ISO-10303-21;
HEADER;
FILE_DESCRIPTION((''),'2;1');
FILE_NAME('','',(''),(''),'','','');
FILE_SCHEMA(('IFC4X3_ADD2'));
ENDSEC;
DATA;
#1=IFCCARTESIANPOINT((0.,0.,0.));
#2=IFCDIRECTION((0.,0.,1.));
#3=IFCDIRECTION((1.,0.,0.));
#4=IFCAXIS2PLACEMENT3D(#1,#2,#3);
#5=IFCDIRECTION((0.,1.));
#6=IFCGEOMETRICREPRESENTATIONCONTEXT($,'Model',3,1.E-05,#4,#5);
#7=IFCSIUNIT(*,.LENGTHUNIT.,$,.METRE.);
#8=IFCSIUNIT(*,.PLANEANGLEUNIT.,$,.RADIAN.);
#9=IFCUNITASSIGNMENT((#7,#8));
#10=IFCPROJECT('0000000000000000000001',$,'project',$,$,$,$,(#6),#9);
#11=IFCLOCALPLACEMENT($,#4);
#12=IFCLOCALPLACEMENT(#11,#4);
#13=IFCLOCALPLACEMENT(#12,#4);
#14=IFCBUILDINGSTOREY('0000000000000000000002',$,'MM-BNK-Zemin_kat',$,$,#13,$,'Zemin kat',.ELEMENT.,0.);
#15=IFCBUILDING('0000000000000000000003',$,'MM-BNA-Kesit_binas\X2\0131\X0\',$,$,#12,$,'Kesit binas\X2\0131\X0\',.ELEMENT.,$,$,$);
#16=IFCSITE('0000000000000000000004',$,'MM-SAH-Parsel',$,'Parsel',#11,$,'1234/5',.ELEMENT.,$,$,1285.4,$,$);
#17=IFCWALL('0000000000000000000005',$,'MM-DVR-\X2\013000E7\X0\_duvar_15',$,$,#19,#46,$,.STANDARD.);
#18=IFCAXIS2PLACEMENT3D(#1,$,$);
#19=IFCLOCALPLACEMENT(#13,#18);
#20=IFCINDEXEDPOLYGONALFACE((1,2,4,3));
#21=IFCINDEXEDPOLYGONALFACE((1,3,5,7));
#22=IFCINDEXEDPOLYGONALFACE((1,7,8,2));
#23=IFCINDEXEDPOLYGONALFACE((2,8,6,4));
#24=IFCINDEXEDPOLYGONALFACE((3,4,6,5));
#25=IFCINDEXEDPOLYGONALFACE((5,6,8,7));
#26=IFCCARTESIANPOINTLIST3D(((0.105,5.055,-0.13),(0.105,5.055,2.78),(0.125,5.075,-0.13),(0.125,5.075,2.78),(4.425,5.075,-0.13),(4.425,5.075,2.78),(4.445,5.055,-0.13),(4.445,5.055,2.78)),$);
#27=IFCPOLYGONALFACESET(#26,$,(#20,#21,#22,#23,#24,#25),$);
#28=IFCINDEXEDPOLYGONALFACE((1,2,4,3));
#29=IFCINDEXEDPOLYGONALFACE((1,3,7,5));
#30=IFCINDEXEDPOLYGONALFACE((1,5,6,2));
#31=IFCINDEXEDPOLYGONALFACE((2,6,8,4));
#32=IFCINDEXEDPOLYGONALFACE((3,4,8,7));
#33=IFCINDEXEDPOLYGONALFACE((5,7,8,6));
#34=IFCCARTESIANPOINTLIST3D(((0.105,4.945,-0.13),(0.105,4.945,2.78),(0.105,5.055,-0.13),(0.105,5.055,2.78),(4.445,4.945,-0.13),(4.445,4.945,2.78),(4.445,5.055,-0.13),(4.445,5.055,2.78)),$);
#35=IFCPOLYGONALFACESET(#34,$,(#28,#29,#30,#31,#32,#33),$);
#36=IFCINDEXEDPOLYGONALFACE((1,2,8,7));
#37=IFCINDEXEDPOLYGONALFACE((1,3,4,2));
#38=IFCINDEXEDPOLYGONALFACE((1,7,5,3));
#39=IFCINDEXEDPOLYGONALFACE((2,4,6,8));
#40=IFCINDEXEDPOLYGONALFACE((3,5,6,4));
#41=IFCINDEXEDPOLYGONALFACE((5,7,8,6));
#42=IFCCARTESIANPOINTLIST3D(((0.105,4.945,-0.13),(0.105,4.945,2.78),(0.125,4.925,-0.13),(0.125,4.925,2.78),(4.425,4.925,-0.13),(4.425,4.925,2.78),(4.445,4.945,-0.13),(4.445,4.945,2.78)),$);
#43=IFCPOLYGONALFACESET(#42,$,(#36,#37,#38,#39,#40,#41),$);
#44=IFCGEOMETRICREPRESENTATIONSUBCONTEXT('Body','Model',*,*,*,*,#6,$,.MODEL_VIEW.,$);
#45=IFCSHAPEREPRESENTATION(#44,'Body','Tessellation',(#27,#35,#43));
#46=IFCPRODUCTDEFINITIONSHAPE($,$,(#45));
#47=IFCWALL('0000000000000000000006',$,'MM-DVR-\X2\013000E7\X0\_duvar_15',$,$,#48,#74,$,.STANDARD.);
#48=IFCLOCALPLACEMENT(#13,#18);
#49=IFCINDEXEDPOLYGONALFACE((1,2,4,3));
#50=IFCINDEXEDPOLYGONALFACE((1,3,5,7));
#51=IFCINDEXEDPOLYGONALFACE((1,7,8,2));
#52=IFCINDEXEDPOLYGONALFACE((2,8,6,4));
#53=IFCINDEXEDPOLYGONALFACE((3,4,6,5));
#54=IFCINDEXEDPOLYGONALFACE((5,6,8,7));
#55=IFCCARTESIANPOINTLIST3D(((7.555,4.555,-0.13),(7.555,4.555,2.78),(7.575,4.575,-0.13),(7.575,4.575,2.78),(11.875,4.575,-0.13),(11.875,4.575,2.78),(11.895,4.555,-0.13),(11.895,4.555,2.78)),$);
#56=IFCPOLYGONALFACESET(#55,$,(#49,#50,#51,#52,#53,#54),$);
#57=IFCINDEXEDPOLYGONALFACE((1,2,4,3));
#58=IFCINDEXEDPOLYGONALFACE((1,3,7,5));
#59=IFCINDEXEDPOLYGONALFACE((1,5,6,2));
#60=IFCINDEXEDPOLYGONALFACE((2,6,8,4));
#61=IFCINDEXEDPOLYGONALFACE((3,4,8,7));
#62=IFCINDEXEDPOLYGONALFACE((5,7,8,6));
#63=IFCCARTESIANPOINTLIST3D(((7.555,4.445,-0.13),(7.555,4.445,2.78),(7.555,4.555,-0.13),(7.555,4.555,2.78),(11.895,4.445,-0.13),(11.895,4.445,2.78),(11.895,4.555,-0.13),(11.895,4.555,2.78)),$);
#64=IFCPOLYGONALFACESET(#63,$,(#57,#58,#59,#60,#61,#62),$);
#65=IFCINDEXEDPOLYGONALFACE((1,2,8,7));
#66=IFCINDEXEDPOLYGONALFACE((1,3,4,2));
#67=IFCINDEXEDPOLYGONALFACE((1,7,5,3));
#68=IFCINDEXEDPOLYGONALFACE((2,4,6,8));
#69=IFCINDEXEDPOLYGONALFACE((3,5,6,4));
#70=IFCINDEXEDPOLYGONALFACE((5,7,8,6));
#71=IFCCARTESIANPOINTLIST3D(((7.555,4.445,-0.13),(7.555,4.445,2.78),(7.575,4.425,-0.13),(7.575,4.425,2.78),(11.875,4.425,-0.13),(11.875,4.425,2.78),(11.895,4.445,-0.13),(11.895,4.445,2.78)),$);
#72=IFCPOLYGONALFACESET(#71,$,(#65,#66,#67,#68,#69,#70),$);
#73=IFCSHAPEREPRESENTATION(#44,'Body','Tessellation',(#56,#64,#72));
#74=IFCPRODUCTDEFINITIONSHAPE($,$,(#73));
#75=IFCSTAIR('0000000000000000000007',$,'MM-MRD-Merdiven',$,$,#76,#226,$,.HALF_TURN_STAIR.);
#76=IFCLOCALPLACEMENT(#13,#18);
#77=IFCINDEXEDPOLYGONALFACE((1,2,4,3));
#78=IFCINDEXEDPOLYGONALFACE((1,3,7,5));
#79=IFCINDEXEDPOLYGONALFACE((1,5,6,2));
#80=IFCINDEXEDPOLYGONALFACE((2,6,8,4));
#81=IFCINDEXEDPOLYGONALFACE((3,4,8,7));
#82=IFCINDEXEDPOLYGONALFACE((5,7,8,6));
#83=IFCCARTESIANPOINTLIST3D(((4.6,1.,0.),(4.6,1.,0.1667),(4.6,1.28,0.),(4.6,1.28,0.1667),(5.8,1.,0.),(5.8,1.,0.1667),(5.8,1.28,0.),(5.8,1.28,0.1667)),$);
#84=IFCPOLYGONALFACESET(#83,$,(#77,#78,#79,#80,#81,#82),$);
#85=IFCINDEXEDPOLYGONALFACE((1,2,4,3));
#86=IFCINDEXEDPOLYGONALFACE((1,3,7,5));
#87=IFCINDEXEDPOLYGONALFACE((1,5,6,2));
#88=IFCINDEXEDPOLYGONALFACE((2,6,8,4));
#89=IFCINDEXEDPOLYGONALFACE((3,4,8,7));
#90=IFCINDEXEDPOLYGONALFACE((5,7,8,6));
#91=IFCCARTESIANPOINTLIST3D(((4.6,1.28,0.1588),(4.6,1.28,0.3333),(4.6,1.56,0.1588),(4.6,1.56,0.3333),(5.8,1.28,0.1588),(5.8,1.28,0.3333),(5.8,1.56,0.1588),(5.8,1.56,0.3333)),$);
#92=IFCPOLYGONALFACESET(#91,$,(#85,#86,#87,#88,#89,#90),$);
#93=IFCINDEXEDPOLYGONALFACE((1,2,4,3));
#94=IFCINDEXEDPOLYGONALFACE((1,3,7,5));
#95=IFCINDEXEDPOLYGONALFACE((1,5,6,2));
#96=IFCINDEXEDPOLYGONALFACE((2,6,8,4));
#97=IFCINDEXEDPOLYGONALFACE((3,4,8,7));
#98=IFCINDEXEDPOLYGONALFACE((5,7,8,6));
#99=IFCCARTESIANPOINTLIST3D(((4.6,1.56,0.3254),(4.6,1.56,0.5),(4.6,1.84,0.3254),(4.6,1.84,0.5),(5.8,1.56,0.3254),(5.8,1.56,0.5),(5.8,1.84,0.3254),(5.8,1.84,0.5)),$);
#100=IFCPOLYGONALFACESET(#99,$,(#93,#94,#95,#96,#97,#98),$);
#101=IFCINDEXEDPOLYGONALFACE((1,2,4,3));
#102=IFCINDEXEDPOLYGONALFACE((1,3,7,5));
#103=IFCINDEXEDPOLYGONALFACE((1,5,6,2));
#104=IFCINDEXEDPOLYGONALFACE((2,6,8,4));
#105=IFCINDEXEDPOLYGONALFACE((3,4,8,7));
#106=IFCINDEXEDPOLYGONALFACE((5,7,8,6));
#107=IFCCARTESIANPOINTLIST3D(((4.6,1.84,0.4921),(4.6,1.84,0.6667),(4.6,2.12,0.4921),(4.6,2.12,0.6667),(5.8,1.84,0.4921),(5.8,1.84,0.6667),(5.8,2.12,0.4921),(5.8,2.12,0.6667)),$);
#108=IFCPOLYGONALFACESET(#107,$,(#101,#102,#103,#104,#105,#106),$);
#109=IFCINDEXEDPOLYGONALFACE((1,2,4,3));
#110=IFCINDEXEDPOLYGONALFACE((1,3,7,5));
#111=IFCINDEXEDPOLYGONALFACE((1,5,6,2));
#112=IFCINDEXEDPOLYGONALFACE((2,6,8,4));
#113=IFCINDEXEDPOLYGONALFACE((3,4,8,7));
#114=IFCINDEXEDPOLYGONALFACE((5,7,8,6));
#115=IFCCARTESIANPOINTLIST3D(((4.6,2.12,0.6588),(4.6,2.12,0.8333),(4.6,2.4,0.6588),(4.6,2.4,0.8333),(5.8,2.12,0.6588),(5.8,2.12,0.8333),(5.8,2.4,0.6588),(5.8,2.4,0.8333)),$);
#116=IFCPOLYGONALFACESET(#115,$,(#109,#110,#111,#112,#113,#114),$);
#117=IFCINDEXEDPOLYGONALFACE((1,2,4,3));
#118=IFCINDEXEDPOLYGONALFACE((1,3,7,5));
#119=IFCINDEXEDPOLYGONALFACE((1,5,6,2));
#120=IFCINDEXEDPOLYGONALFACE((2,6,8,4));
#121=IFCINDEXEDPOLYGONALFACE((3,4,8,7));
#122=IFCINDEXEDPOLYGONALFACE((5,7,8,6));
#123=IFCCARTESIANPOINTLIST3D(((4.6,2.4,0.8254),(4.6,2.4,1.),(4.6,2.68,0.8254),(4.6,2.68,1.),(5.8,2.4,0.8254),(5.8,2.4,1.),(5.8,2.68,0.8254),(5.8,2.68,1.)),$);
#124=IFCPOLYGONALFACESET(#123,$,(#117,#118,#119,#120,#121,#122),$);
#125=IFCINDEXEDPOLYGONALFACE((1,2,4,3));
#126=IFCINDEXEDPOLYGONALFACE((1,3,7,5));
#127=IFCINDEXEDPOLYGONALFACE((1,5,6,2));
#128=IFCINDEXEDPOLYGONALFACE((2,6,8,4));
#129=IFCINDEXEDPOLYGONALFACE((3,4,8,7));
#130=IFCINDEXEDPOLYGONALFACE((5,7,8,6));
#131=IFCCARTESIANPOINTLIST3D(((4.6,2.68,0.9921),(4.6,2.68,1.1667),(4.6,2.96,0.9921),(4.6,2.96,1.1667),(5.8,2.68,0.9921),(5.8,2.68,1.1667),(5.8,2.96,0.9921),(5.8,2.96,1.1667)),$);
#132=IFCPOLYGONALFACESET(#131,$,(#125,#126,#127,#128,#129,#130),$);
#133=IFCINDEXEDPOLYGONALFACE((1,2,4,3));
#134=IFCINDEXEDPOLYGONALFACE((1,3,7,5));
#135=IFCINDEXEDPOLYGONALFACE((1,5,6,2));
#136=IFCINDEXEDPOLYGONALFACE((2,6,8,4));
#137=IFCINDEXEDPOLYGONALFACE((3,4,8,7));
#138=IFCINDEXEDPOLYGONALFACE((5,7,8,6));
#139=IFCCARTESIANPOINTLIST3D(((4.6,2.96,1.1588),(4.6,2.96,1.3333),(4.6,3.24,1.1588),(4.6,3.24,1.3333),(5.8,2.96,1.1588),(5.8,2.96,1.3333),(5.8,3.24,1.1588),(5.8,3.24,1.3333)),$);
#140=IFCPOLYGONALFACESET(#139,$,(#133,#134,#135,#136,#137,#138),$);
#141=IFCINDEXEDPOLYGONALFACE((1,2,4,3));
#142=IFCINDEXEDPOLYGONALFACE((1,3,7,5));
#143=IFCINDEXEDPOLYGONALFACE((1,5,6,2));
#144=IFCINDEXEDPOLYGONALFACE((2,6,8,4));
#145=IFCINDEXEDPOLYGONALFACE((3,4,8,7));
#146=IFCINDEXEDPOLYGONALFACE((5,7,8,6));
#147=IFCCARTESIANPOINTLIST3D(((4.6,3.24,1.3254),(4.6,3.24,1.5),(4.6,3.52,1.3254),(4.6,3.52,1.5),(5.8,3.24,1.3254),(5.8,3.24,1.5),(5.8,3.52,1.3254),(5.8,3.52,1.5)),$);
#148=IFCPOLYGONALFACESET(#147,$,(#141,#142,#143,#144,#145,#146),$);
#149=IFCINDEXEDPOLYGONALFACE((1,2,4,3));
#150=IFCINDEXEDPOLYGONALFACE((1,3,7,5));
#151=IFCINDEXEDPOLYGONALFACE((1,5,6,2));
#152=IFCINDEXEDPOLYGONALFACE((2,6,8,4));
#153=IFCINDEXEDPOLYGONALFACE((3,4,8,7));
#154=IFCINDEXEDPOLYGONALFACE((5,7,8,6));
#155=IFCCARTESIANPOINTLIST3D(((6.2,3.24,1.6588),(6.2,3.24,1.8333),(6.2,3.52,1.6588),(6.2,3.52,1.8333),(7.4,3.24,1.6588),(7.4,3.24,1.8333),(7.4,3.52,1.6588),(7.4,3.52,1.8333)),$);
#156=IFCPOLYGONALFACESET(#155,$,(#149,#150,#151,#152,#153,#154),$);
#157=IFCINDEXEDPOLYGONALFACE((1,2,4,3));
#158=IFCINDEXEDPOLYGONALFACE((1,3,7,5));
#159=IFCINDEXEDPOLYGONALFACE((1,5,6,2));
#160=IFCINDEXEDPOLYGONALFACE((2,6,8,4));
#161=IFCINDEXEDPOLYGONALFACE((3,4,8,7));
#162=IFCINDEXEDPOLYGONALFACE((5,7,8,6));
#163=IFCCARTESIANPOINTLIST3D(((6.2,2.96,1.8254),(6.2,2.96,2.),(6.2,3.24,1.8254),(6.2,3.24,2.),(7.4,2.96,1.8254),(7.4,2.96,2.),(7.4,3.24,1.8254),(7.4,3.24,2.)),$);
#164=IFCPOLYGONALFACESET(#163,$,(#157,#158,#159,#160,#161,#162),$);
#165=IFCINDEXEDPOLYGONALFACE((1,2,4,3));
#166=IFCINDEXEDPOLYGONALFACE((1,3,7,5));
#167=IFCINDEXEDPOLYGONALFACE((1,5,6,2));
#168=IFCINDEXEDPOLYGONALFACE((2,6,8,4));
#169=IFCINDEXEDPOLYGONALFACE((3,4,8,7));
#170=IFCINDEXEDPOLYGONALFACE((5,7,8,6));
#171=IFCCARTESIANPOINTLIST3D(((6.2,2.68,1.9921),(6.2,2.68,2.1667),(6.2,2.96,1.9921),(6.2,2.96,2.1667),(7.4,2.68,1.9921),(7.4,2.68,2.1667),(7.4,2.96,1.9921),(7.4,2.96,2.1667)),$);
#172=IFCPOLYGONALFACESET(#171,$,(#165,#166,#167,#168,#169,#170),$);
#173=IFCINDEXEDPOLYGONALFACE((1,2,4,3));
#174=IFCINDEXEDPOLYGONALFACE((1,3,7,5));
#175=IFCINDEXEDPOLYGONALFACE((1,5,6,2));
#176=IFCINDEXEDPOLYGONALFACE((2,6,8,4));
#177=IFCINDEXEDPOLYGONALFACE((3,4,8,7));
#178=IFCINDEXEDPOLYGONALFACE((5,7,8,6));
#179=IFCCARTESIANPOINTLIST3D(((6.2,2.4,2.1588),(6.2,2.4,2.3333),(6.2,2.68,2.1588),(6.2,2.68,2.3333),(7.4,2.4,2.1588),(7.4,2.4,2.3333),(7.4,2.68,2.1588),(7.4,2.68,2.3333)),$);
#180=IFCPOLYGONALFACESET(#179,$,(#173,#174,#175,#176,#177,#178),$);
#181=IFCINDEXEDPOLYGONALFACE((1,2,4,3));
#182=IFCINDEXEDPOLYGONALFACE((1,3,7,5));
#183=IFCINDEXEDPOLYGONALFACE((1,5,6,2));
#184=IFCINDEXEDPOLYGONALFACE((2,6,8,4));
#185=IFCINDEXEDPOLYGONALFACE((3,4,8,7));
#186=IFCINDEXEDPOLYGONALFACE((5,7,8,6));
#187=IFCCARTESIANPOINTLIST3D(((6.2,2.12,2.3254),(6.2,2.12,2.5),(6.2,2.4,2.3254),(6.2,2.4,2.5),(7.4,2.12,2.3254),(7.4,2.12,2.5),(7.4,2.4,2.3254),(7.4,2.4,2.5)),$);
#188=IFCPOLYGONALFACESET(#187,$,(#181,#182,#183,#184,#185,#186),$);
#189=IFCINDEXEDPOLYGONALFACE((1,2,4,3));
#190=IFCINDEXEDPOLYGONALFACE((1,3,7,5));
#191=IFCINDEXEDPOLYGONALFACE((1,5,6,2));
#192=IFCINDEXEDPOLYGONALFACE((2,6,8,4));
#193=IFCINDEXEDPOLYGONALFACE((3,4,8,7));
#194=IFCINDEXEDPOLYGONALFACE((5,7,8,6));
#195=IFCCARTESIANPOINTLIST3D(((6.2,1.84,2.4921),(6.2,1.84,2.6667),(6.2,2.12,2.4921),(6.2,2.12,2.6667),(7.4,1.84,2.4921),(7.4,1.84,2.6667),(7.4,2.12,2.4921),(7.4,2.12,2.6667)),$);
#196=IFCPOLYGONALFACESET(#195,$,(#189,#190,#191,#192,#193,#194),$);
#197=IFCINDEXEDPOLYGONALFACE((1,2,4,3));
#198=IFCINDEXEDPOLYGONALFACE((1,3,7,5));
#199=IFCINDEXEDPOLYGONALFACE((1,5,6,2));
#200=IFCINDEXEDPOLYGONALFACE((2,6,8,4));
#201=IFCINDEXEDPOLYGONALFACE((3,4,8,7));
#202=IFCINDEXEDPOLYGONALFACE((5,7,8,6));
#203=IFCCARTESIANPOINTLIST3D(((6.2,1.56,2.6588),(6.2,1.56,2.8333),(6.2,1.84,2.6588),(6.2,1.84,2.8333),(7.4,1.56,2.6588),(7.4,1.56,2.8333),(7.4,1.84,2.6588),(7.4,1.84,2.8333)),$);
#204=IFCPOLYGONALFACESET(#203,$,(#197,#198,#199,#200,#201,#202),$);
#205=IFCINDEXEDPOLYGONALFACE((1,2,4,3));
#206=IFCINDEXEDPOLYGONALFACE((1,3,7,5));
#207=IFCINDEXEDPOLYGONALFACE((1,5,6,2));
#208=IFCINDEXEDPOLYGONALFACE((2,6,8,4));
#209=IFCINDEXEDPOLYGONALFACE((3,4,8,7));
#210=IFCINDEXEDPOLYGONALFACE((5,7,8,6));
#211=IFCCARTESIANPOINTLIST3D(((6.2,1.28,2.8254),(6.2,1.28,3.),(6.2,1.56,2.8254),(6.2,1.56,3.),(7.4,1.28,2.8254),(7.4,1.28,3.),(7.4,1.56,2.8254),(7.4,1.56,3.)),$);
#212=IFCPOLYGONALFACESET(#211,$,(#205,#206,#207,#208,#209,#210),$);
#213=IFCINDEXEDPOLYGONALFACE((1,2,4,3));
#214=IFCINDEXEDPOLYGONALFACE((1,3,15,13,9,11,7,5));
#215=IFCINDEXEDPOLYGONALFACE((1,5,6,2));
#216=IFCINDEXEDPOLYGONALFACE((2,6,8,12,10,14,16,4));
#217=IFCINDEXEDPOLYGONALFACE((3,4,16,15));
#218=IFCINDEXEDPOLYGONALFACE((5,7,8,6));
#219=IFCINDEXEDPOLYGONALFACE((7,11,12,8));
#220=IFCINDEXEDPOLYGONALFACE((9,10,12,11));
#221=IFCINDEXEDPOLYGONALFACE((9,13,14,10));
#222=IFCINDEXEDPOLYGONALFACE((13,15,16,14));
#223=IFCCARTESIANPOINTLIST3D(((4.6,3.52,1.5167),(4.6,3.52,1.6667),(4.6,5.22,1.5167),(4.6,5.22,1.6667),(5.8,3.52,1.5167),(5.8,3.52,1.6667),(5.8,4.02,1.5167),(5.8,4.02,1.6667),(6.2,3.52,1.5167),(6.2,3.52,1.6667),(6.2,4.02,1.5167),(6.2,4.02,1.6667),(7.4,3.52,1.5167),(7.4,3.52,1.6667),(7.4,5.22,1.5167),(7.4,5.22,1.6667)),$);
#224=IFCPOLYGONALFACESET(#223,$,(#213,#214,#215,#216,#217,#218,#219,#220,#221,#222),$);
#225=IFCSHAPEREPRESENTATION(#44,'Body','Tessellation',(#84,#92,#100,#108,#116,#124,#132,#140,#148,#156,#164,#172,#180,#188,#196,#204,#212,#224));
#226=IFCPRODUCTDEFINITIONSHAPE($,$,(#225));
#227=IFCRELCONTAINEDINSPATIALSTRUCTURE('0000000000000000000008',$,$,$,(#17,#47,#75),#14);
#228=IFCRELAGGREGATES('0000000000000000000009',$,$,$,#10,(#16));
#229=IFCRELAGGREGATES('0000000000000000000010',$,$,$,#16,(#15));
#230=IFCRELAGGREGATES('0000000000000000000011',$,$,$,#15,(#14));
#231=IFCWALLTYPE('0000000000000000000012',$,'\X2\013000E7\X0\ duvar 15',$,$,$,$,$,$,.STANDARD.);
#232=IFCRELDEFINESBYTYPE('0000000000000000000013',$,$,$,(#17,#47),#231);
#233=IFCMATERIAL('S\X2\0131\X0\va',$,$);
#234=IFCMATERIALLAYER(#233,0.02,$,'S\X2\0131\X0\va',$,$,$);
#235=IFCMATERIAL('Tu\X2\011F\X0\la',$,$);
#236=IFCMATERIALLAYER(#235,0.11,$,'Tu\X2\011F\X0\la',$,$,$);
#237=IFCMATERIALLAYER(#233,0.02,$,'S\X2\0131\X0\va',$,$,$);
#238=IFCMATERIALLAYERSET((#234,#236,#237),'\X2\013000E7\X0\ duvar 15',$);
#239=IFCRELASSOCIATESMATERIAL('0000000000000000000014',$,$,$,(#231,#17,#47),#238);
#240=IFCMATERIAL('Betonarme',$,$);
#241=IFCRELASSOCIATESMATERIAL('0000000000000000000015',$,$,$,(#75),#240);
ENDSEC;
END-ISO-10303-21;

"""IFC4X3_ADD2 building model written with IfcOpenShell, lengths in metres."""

from ifc_helpers import new_model, si_unit, direction, frame, origin, origin_with_axes, place, context, subcontext, project, spatial, polyline, outline, extrude, material, layer, layer_set, type_object, element, save


model = new_model("IFC4X3_ADD2")

# Units and contexts
model_context = context("Model", 3, precision=1e-05, world=origin_with_axes(), true_north=direction((0.0, 1.0)))
body_context = subcontext(model_context, "Body", "Model", "MODEL_VIEW")
ifc_project = project(units=[si_unit("LENGTHUNIT", "METRE"), si_unit("PLANEANGLEUNIT", "RADIAN")], contexts=[model_context])

# Site, building, storey
site_placement = place(None, origin_with_axes())
site = spatial("IfcSite", under=ifc_project, at=site_placement, Name="MM-SAH-Parsel", ObjectType="Parsel", LongName="1234/5", CompositionType="ELEMENT", RefElevation=1285.4)
building_placement = place(site_placement, origin_with_axes())
building = spatial("IfcBuilding", under=site, at=building_placement, Name="MM-BNA-Kesit_binası", LongName="Kesit binası", CompositionType="ELEMENT")
storey_placement = place(building_placement, origin_with_axes())
storey = spatial("IfcBuildingStorey", under=building, at=storey_placement, Name="MM-BNK-Zemin_kat", LongName="Zemin kat", CompositionType="ELEMENT", Elevation=0.0)

# Shared definitions
ifc_material_1 = material(Name="Betonarme")

# Shared definitions
ifc_material_2 = material(Name="Tuğla")

# Shared definitions
ifc_material_3 = material(Name="Sıva")
ifc_layer_1 = layer(ifc_material_3, 0.02, Name="Sıva")
ifc_layer_2 = layer(ifc_material_2, 0.11, Name="Tuğla")
ifc_layer_3 = layer(ifc_material_3, 0.02, Name="Sıva")
ifc_layer_set_1 = layer_set([ifc_layer_1, ifc_layer_2, ifc_layer_3], Name="İç duvar 15")
wall_type_1 = type_object("IfcWallType", Name="İç duvar 15", PredefinedType="STANDARD", material=ifc_layer_set_1)

# Walls
wall_1_placement = place(storey_placement, frame((0.0, 0.5, 0.0), z_axis=(0.0, 0.0, 1.0), x_axis=(1.0, 0.0, 0.0)))
element("IfcWall", 1, at=wall_1_placement, inside=storey, type_object=wall_type_1, material=ifc_layer_set_1, Name="MM-DVR-İç_duvar_15", PredefinedType="STANDARD", context=body_context, shape_type="SweptSolid", body=[
    extrude(outline(polyline([(0.125, 4.575), (4.425, 4.575), (4.445, 4.555), (0.105, 4.555), (0.125, 4.575)])), frame((0.0, 0.0, -0.13)), (0.0, 0.0, 1.0), 2.91),
    extrude(outline(polyline([(0.105, 4.555), (4.445, 4.555), (4.445, 4.445), (0.105, 4.445), (0.105, 4.555)])), frame((0.0, 0.0, -0.13)), (0.0, 0.0, 1.0), 2.91),
    extrude(outline(polyline([(0.105, 4.445), (4.445, 4.445), (4.425, 4.425), (0.125, 4.425), (0.105, 4.445)])), frame((0.0, 0.0, -0.13)), (0.0, 0.0, 1.0), 2.91),
])
wall_2_placement = place(storey_placement, origin_with_axes())
element("IfcWall", 2, at=wall_2_placement, inside=storey, type_object=wall_type_1, material=ifc_layer_set_1, Name="MM-DVR-İç_duvar_15", PredefinedType="STANDARD", context=body_context, shape_type="SweptSolid", body=[
    extrude(outline(polyline([(7.575, 4.575), (11.875, 4.575), (11.895, 4.555), (7.555, 4.555), (7.575, 4.575)])), frame((0.0, 0.0, -0.13)), (0.0, 0.0, 1.0), 2.91),
    extrude(outline(polyline([(7.555, 4.555), (11.895, 4.555), (11.895, 4.445), (7.555, 4.445), (7.555, 4.555)])), frame((0.0, 0.0, -0.13)), (0.0, 0.0, 1.0), 2.91),
    extrude(outline(polyline([(7.555, 4.445), (11.895, 4.445), (11.875, 4.425), (7.575, 4.425), (7.555, 4.445)])), frame((0.0, 0.0, -0.13)), (0.0, 0.0, 1.0), 2.91),
])

# Stair
stair_placement = place(storey_placement, origin_with_axes())
element("IfcStair", 3, at=stair_placement, inside=storey, material=ifc_material_1, Name="MM-MRD-Merdiven", PredefinedType="HALF_TURN_STAIR", context=body_context, shape_type="SweptSolid", body=[
    extrude(outline(polyline([(5.8, 1.0), (5.8, 1.28), (4.6, 1.28), (4.6, 1.0), (5.8, 1.0)])), origin(), (0.0, 0.0, 1.0), 0.1667),
    extrude(outline(polyline([(5.8, 1.28), (5.8, 1.56), (4.6, 1.56), (4.6, 1.28), (5.8, 1.28)])), frame((0.0, 0.0, 0.1588)), (0.0, 0.0, 1.0), 0.1746),
    extrude(outline(polyline([(5.8, 1.56), (5.8, 1.84), (4.6, 1.84), (4.6, 1.56), (5.8, 1.56)])), frame((0.0, 0.0, 0.3254)), (0.0, 0.0, 1.0), 0.1746),
    extrude(outline(polyline([(5.8, 1.84), (5.8, 2.12), (4.6, 2.12), (4.6, 1.84), (5.8, 1.84)])), frame((0.0, 0.0, 0.4921)), (0.0, 0.0, 1.0), 0.1746),
    extrude(outline(polyline([(5.8, 2.12), (5.8, 2.4), (4.6, 2.4), (4.6, 2.12), (5.8, 2.12)])), frame((0.0, 0.0, 0.6588)), (0.0, 0.0, 1.0), 0.1746),
    extrude(outline(polyline([(5.8, 2.4), (5.8, 2.68), (4.6, 2.68), (4.6, 2.4), (5.8, 2.4)])), frame((0.0, 0.0, 0.8254)), (0.0, 0.0, 1.0), 0.1746),
    extrude(outline(polyline([(5.8, 2.68), (5.8, 2.96), (4.6, 2.96), (4.6, 2.68), (5.8, 2.68)])), frame((0.0, 0.0, 0.9921)), (0.0, 0.0, 1.0), 0.1746),
    extrude(outline(polyline([(5.8, 2.96), (5.8, 3.24), (4.6, 3.24), (4.6, 2.96), (5.8, 2.96)])), frame((0.0, 0.0, 1.1588)), (0.0, 0.0, 1.0), 0.1746),
    extrude(outline(polyline([(5.8, 3.24), (5.8, 3.52), (4.6, 3.52), (4.6, 3.24), (5.8, 3.24)])), frame((0.0, 0.0, 1.3254)), (0.0, 0.0, 1.0), 0.1746),
    extrude(outline(polyline([(6.2, 3.52), (6.2, 3.24), (7.4, 3.24), (7.4, 3.52), (6.2, 3.52)])), frame((0.0, 0.0, 1.6588)), (0.0, 0.0, 1.0), 0.1746),
    extrude(outline(polyline([(6.2, 3.24), (6.2, 2.96), (7.4, 2.96), (7.4, 3.24), (6.2, 3.24)])), frame((0.0, 0.0, 1.8254)), (0.0, 0.0, 1.0), 0.1746),
    extrude(outline(polyline([(6.2, 2.96), (6.2, 2.68), (7.4, 2.68), (7.4, 2.96), (6.2, 2.96)])), frame((0.0, 0.0, 1.9921)), (0.0, 0.0, 1.0), 0.1746),
    extrude(outline(polyline([(6.2, 2.68), (6.2, 2.4), (7.4, 2.4), (7.4, 2.68), (6.2, 2.68)])), frame((0.0, 0.0, 2.1588)), (0.0, 0.0, 1.0), 0.1746),
    extrude(outline(polyline([(6.2, 2.4), (6.2, 2.12), (7.4, 2.12), (7.4, 2.4), (6.2, 2.4)])), frame((0.0, 0.0, 2.3254)), (0.0, 0.0, 1.0), 0.1746),
    extrude(outline(polyline([(6.2, 2.12), (6.2, 1.84), (7.4, 1.84), (7.4, 2.12), (6.2, 2.12)])), frame((0.0, 0.0, 2.4921)), (0.0, 0.0, 1.0), 0.1746),
    extrude(outline(polyline([(6.2, 1.84), (6.2, 1.56), (7.4, 1.56), (7.4, 1.84), (6.2, 1.84)])), frame((0.0, 0.0, 2.6588)), (0.0, 0.0, 1.0), 0.1746),
    extrude(outline(polyline([(6.2, 1.56), (6.2, 1.28), (7.4, 1.28), (7.4, 1.56), (6.2, 1.56)])), frame((0.0, 0.0, 2.8254)), (0.0, 0.0, 1.0), 0.1746),
    extrude(outline(polyline([(4.6, 3.52), (4.6, 5.22), (7.4, 5.22), (7.4, 3.52), (6.2, 3.52), (6.2, 4.02), (5.8, 4.02), (5.8, 3.52), (4.6, 3.52)])), frame((0.0, 0.0, 1.5167)), (0.0, 0.0, 1.0), 0.15),
])

save(model, "model.ifc")
